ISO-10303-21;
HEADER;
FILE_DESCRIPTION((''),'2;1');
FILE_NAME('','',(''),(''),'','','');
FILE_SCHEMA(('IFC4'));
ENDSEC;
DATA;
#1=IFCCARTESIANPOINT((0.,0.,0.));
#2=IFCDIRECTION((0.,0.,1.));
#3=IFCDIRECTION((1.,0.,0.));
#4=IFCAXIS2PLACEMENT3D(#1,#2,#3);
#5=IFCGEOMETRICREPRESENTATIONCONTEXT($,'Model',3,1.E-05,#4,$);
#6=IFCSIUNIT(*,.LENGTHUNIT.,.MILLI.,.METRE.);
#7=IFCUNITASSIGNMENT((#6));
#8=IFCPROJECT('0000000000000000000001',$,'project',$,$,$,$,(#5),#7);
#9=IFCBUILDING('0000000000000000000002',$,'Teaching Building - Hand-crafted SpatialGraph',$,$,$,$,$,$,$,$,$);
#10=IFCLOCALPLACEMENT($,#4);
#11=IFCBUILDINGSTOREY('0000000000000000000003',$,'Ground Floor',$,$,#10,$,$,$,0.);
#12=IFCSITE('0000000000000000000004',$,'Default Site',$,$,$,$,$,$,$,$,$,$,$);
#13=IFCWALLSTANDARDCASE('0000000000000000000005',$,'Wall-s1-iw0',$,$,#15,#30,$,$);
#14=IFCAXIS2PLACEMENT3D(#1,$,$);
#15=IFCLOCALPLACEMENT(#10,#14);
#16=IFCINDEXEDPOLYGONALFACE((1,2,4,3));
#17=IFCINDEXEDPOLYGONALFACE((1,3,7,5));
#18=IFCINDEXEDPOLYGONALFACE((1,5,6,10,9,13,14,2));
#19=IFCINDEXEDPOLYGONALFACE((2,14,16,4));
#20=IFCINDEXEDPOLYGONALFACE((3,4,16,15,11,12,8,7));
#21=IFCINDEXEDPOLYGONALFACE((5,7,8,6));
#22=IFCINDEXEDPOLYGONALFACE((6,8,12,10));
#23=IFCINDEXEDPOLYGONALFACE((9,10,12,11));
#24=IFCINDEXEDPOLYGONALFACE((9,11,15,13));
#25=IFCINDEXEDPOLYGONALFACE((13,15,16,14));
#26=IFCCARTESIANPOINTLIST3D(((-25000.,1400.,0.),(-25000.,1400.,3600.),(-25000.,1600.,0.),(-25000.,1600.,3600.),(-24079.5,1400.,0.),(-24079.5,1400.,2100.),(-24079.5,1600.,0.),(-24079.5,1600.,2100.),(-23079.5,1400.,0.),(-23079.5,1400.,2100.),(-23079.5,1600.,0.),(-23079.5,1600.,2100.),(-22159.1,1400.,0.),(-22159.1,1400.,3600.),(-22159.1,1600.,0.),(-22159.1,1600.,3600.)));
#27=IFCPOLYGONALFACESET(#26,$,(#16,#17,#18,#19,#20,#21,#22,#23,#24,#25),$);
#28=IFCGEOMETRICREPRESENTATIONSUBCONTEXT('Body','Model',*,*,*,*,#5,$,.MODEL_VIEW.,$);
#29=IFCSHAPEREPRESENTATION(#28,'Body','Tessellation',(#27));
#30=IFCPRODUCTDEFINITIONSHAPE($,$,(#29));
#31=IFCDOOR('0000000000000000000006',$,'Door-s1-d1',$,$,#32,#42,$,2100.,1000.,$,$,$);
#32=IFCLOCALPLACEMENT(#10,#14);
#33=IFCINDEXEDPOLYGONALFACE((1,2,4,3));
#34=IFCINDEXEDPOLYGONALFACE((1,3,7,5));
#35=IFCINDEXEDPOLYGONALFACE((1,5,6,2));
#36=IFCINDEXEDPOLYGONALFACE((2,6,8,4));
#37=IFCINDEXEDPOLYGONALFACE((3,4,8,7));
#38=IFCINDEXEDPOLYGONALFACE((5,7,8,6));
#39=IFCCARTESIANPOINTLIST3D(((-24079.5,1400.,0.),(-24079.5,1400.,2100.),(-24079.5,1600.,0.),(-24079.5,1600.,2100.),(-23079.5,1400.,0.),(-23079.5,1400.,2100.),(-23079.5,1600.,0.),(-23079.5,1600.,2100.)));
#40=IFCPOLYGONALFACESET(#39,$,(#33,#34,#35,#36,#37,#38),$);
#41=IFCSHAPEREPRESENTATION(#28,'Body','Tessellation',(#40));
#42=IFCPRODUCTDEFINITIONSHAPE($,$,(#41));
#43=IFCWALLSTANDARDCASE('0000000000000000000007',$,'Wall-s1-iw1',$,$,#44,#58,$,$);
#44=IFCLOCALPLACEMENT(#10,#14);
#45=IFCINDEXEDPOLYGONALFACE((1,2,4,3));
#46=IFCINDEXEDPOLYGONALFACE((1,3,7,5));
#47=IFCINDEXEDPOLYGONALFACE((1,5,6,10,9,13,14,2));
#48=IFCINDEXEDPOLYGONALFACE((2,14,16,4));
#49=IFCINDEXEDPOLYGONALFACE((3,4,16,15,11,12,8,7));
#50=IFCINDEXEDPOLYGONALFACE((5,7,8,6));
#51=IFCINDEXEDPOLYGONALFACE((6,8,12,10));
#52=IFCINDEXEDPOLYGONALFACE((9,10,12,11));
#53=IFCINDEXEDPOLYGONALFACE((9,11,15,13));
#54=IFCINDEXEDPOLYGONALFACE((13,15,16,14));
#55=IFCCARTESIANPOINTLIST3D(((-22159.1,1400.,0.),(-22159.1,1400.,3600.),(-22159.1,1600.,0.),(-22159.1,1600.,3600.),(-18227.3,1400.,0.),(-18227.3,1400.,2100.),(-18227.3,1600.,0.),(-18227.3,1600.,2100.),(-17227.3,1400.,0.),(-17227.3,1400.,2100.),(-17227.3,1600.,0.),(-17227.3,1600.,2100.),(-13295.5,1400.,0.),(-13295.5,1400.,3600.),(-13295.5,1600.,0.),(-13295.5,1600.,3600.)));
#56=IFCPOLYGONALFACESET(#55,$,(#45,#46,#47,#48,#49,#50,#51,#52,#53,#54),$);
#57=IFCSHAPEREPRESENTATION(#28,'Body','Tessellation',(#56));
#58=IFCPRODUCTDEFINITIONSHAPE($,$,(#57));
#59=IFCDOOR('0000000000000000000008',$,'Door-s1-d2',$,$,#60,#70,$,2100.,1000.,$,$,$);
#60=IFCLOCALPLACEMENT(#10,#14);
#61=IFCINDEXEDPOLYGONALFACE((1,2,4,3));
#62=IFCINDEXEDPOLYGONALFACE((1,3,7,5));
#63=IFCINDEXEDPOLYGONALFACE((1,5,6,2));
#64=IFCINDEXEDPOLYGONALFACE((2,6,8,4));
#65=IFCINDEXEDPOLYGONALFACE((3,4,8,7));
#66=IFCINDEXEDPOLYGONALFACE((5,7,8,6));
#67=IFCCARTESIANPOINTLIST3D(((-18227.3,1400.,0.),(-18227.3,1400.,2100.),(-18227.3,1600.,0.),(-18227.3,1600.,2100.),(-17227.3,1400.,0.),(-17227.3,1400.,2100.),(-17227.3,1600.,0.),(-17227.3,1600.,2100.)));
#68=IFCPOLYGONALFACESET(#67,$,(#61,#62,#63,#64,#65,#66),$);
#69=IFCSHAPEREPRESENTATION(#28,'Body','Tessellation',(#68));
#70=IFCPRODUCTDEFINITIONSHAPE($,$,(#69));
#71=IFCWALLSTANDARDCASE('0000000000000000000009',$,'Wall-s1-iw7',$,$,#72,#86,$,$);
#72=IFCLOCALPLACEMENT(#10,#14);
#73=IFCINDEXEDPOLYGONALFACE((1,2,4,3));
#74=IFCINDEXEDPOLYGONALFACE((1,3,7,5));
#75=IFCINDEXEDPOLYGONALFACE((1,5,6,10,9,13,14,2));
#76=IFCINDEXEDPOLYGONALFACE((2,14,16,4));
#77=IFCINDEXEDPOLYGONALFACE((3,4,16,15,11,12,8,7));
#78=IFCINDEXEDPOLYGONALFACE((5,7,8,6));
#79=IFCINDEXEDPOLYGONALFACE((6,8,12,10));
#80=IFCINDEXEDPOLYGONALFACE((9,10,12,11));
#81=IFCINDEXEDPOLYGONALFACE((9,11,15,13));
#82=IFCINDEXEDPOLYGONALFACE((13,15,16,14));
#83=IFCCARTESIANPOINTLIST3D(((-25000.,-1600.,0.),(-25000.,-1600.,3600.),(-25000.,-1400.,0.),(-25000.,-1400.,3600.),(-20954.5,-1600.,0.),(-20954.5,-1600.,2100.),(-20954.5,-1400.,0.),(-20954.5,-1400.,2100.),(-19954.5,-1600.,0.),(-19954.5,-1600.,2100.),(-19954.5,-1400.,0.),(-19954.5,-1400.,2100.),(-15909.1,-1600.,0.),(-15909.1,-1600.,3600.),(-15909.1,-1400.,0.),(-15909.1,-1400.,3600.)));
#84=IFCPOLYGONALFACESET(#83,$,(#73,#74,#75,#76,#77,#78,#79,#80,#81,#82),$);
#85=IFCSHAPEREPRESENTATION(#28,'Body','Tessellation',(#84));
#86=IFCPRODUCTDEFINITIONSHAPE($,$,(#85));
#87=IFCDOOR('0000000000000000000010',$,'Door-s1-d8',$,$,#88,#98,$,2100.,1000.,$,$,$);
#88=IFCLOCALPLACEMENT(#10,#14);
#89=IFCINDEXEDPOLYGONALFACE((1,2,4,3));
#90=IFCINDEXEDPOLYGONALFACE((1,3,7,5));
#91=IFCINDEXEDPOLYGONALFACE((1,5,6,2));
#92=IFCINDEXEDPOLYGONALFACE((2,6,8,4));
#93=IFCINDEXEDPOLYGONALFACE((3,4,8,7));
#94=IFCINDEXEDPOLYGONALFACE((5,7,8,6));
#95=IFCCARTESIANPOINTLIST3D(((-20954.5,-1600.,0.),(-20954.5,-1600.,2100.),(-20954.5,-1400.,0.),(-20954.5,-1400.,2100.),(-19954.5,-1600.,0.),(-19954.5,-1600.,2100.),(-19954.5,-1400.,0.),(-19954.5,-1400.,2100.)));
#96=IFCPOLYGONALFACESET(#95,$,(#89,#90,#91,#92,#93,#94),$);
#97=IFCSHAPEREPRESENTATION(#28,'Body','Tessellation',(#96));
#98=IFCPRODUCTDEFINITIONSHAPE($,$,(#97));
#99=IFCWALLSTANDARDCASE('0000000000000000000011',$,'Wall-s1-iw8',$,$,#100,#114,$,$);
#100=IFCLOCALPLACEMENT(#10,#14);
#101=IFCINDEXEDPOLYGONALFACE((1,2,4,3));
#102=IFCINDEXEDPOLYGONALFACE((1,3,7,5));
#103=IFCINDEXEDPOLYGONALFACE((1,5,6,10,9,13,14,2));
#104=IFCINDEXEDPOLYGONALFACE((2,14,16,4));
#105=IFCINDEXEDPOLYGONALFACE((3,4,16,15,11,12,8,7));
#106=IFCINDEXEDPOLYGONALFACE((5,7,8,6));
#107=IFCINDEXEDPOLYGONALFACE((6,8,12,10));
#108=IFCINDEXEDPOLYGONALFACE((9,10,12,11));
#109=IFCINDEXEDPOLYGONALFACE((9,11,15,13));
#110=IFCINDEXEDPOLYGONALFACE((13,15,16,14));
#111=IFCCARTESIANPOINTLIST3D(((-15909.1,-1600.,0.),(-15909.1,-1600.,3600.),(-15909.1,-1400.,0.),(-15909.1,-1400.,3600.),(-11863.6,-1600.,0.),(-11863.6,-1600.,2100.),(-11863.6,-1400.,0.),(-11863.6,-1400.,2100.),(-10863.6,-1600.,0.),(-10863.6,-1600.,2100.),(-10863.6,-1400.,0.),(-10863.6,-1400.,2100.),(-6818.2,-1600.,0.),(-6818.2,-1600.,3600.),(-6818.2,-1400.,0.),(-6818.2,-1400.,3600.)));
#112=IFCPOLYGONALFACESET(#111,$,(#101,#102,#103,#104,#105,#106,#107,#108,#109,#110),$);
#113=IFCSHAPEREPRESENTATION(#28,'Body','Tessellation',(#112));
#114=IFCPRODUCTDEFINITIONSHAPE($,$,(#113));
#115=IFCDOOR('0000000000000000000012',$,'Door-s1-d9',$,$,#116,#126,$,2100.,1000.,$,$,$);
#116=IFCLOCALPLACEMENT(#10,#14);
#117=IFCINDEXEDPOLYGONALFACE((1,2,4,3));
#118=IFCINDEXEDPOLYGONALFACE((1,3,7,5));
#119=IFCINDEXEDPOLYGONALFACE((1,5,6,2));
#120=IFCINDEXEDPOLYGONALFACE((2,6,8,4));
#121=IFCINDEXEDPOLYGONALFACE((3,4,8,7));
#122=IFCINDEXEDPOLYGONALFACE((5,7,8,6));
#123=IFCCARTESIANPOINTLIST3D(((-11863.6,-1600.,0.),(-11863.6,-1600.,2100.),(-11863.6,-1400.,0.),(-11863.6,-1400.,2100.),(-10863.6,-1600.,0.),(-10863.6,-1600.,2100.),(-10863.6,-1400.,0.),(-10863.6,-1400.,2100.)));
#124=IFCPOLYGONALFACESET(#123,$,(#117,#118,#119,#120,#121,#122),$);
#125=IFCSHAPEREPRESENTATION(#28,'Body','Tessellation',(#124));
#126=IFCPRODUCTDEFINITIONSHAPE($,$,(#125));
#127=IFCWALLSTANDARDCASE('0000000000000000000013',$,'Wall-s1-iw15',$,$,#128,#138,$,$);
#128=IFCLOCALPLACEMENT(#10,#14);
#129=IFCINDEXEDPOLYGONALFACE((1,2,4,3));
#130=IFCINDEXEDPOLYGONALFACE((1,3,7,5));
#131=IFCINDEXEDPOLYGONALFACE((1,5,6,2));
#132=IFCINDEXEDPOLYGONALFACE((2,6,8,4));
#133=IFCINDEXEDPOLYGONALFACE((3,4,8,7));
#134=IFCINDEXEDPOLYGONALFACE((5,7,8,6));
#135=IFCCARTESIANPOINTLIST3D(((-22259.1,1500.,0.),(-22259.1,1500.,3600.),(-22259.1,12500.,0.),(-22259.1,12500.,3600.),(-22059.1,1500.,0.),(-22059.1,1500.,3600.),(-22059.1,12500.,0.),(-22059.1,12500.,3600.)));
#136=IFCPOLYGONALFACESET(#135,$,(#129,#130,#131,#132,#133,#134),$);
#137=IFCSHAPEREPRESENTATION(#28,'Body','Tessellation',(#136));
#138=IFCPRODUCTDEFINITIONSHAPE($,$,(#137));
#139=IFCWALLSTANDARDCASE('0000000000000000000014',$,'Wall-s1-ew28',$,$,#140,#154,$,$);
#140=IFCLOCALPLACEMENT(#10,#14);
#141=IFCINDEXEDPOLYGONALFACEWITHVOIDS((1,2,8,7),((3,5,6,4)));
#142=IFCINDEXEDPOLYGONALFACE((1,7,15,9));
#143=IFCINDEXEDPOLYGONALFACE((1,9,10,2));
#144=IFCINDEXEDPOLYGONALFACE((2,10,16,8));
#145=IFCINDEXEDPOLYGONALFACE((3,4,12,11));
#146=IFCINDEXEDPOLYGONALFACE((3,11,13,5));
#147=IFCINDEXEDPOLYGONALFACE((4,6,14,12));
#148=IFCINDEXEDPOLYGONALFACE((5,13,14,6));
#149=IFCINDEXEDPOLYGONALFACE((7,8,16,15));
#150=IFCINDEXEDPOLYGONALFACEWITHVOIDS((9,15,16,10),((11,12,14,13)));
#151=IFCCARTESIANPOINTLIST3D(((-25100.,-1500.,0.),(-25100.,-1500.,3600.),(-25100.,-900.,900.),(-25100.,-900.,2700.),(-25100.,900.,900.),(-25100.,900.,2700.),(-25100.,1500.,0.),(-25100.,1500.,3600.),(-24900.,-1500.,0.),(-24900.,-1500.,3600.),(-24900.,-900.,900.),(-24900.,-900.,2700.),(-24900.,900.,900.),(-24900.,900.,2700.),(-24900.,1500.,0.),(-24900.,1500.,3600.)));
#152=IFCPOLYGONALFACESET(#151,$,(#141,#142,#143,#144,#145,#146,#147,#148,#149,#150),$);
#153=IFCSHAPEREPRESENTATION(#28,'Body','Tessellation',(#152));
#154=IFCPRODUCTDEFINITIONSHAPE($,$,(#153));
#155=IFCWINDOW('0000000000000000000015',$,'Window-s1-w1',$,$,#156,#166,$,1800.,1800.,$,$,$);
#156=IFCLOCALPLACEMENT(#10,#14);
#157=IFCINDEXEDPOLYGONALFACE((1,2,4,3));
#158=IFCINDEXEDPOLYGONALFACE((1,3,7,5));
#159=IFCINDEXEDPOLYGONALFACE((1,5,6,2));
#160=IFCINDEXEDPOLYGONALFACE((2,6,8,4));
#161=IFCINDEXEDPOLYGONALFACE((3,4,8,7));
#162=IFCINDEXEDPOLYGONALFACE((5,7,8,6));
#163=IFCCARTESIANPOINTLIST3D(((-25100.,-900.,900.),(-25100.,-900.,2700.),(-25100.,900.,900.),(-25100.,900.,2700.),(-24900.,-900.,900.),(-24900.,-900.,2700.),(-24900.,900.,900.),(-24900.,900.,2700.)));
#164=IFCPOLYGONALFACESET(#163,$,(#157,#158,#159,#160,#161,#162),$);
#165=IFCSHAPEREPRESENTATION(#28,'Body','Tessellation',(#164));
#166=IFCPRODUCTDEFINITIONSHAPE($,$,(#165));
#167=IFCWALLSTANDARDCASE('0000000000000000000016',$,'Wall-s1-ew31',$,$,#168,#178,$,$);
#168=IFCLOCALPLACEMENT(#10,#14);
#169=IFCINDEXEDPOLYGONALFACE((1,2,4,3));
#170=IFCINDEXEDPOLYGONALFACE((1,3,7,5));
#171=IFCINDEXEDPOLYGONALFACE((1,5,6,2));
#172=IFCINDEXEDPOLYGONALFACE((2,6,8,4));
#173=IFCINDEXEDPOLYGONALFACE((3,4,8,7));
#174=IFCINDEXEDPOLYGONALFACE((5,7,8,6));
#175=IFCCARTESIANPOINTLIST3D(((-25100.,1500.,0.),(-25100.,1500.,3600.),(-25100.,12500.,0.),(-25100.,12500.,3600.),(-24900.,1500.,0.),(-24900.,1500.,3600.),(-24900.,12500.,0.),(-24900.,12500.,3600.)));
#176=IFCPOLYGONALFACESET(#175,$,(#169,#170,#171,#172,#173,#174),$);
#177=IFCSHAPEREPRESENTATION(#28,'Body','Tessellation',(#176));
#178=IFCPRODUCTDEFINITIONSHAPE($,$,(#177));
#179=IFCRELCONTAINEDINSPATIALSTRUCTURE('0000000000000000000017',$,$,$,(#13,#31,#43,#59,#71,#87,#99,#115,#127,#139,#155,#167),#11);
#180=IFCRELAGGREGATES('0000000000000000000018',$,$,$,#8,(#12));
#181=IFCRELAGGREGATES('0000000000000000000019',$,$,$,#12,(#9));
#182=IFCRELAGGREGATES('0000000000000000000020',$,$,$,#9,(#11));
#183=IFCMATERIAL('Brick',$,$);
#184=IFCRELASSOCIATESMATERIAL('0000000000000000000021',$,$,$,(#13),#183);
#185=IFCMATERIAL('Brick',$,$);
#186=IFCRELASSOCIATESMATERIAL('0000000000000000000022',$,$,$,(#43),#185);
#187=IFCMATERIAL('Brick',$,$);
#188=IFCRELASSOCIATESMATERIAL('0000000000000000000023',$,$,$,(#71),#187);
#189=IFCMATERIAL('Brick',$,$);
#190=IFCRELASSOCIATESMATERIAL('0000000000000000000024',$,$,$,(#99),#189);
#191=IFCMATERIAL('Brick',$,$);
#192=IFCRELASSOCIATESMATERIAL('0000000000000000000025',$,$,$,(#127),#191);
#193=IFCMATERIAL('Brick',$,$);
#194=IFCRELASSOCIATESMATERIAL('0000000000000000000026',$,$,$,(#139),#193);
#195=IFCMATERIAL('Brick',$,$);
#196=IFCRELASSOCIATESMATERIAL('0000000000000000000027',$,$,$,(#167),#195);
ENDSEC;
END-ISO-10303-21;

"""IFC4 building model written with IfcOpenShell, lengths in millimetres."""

from ifc_helpers import new_model, si_unit, frame, frame_2d, origin_with_axes, place, context, subcontext, project, spatial, rectangle, extrude, material, element, fill, save


model = new_model("IFC4")

# Units and contexts
model_context = context("Model", 3, precision=1e-05, world=origin_with_axes())
body_context = subcontext(model_context, "Body", "Model", "MODEL_VIEW")
ifc_project = project(units=[si_unit("LENGTHUNIT", "METRE", prefix="MILLI")], contexts=[model_context])

# Site, building, storey
site = spatial("IfcSite", under=ifc_project, Name="Default Site")
building = spatial("IfcBuilding", under=site, Name="Teaching Building - Hand-crafted SpatialGraph")
storey_placement = place(None, origin_with_axes())
storey = spatial("IfcBuildingStorey", under=building, at=storey_placement, Name="Ground Floor", Elevation=0.0)

# Walls, openings, doors
ifc_material_1 = material(Name="Brick")
wall_1_placement = place(storey_placement, frame((-25000.0, 1500.0, 0.0), z_axis=(0.0, 0.0, 1.0), x_axis=(1.0, 0.0, 0.0)))
wall_1 = element("IfcWallStandardCase", 1, at=wall_1_placement, inside=storey, material=ifc_material_1, Name="Wall-s1-iw0", context=body_context, shape_type="SweptSolid", body=[
    extrude(rectangle(XDim=2840.9, YDim=200.0, at=frame_2d((1420.5, 0.0))), origin_with_axes(), (0.0, 0.0, 1.0), 3600.0),
])
opening_1_placement = place(wall_1_placement, frame((920.5, 0.0, 0.0), z_axis=(0.0, 0.0, 1.0), x_axis=(1.0, 0.0, 0.0)))
opening_1 = element("IfcOpeningElement", 2, at=opening_1_placement, cuts=wall_1, context=body_context, shape_type="SweptSolid", body=[
    extrude(rectangle(XDim=1000.0, YDim=400.0, at=frame_2d((500.0, 0.0))), origin_with_axes(), (0.0, 0.0, 1.0), 2100.0),
])
door_1_placement = place(storey_placement, frame((-24079.5, 1500.0, 0.0), z_axis=(0.0, 0.0, 1.0), x_axis=(1.0, 0.0, 0.0)))
door_1 = element("IfcDoor", 3, at=door_1_placement, inside=storey, Name="Door-s1-d1", OverallHeight=2100.0, OverallWidth=1000.0, context=body_context, shape_type="SweptSolid", body=[
    extrude(rectangle(XDim=1000.0, YDim=200.0, at=frame_2d((500.0, 0.0))), origin_with_axes(), (0.0, 0.0, 1.0), 2100.0),
])
fill(opening_1, door_1)
ifc_material_2 = material(Name="Brick")
wall_2_placement = place(storey_placement, frame((-22159.1, 1500.0, 0.0), z_axis=(0.0, 0.0, 1.0), x_axis=(1.0, 0.0, 0.0)))
wall_2 = element("IfcWallStandardCase", 4, at=wall_2_placement, inside=storey, material=ifc_material_2, Name="Wall-s1-iw1", context=body_context, shape_type="SweptSolid", body=[
    extrude(rectangle(XDim=8863.6, YDim=200.0, at=frame_2d((4431.8, 0.0))), origin_with_axes(), (0.0, 0.0, 1.0), 3600.0),
])
opening_2_placement = place(wall_2_placement, frame((3931.8, 0.0, 0.0), z_axis=(0.0, 0.0, 1.0), x_axis=(1.0, 0.0, 0.0)))
opening_2 = element("IfcOpeningElement", 5, at=opening_2_placement, cuts=wall_2, context=body_context, shape_type="SweptSolid", body=[
    extrude(rectangle(XDim=1000.0, YDim=400.0, at=frame_2d((500.0, 0.0))), origin_with_axes(), (0.0, 0.0, 1.0), 2100.0),
])
door_2_placement = place(storey_placement, frame((-18227.3, 1500.0, 0.0), z_axis=(0.0, 0.0, 1.0), x_axis=(1.0, 0.0, 0.0)))
door_2 = element("IfcDoor", 6, at=door_2_placement, inside=storey, Name="Door-s1-d2", OverallHeight=2100.0, OverallWidth=1000.0, context=body_context, shape_type="SweptSolid", body=[
    extrude(rectangle(XDim=1000.0, YDim=200.0, at=frame_2d((500.0, 0.0))), origin_with_axes(), (0.0, 0.0, 1.0), 2100.0),
])
fill(opening_2, door_2)
ifc_material_3 = material(Name="Brick")
wall_3_placement = place(storey_placement, frame((-25000.0, -1500.0, 0.0), z_axis=(0.0, 0.0, 1.0), x_axis=(1.0, 0.0, 0.0)))
wall_3 = element("IfcWallStandardCase", 7, at=wall_3_placement, inside=storey, material=ifc_material_3, Name="Wall-s1-iw7", context=body_context, shape_type="SweptSolid", body=[
    extrude(rectangle(XDim=9090.9, YDim=200.0, at=frame_2d((4545.5, 0.0))), origin_with_axes(), (0.0, 0.0, 1.0), 3600.0),
])
opening_3_placement = place(wall_3_placement, frame((4045.5, 0.0, 0.0), z_axis=(0.0, 0.0, 1.0), x_axis=(1.0, 0.0, 0.0)))
opening_3 = element("IfcOpeningElement", 8, at=opening_3_placement, cuts=wall_3, context=body_context, shape_type="SweptSolid", body=[
    extrude(rectangle(XDim=1000.0, YDim=400.0, at=frame_2d((500.0, 0.0))), origin_with_axes(), (0.0, 0.0, 1.0), 2100.0),
])
door_3_placement = place(storey_placement, frame((-20954.5, -1500.0, 0.0), z_axis=(0.0, 0.0, 1.0), x_axis=(1.0, 0.0, 0.0)))
door_3 = element("IfcDoor", 9, at=door_3_placement, inside=storey, Name="Door-s1-d8", OverallHeight=2100.0, OverallWidth=1000.0, context=body_context, shape_type="SweptSolid", body=[
    extrude(rectangle(XDim=1000.0, YDim=200.0, at=frame_2d((500.0, 0.0))), origin_with_axes(), (0.0, 0.0, 1.0), 2100.0),
])
fill(opening_3, door_3)
ifc_material_4 = material(Name="Brick")
wall_4_placement = place(storey_placement, frame((-15909.1, -1500.0, 0.0), z_axis=(0.0, 0.0, 1.0), x_axis=(1.0, 0.0, 0.0)))
wall_4 = element("IfcWallStandardCase", 10, at=wall_4_placement, inside=storey, material=ifc_material_4, Name="Wall-s1-iw8", context=body_context, shape_type="SweptSolid", body=[
    extrude(rectangle(XDim=9090.9, YDim=200.0, at=frame_2d((4545.5, 0.0))), origin_with_axes(), (0.0, 0.0, 1.0), 3600.0),
])
opening_4_placement = place(wall_4_placement, frame((4045.5, 0.0, 0.0), z_axis=(0.0, 0.0, 1.0), x_axis=(1.0, 0.0, 0.0)))
opening_4 = element("IfcOpeningElement", 11, at=opening_4_placement, cuts=wall_4, context=body_context, shape_type="SweptSolid", body=[
    extrude(rectangle(XDim=1000.0, YDim=400.0, at=frame_2d((500.0, 0.0))), origin_with_axes(), (0.0, 0.0, 1.0), 2100.0),
])
door_4_placement = place(storey_placement, frame((-11863.6, -1500.0, 0.0), z_axis=(0.0, 0.0, 1.0), x_axis=(1.0, 0.0, 0.0)))
door_4 = element("IfcDoor", 12, at=door_4_placement, inside=storey, Name="Door-s1-d9", OverallHeight=2100.0, OverallWidth=1000.0, context=body_context, shape_type="SweptSolid", body=[
    extrude(rectangle(XDim=1000.0, YDim=200.0, at=frame_2d((500.0, 0.0))), origin_with_axes(), (0.0, 0.0, 1.0), 2100.0),
])
fill(opening_4, door_4)

# Wall
ifc_material_5 = material(Name="Brick")
wall_5_placement = place(storey_placement, frame((-22159.1, 1500.0, 0.0), z_axis=(0.0, 0.0, 1.0), x_axis=(0.0, 1.0, 0.0)))
element("IfcWallStandardCase", 13, at=wall_5_placement, inside=storey, material=ifc_material_5, Name="Wall-s1-iw15", context=body_context, shape_type="SweptSolid", body=[
    extrude(rectangle(XDim=11000.0, YDim=200.0, at=frame_2d((5500.0, 0.0))), origin_with_axes(), (0.0, 0.0, 1.0), 3600.0),
])

# Wall, opening, window
ifc_material_6 = material(Name="Brick")
wall_6_placement = place(storey_placement, frame((-25000.0, -1500.0, 0.0), z_axis=(0.0, 0.0, 1.0), x_axis=(0.0, 1.0, 0.0)))
wall_6 = element("IfcWallStandardCase", 14, at=wall_6_placement, inside=storey, material=ifc_material_6, Name="Wall-s1-ew28", context=body_context, shape_type="SweptSolid", body=[
    extrude(rectangle(XDim=3000.0, YDim=200.0, at=frame_2d((1500.0, 0.0))), origin_with_axes(), (0.0, 0.0, 1.0), 3600.0),
])
opening_5_placement = place(wall_6_placement, frame((600.0, 0.0, 900.0), z_axis=(0.0, 0.0, 1.0), x_axis=(1.0, 0.0, 0.0)))
opening_5 = element("IfcOpeningElement", 15, at=opening_5_placement, cuts=wall_6, context=body_context, shape_type="SweptSolid", body=[
    extrude(rectangle(XDim=1800.0, YDim=400.0, at=frame_2d((900.0, 0.0))), origin_with_axes(), (0.0, 0.0, 1.0), 1800.0),
])
window_placement = place(storey_placement, frame((-25000.0, -900.0, 900.0), z_axis=(0.0, 0.0, 1.0), x_axis=(0.0, 1.0, 0.0)))
window = element("IfcWindow", 16, at=window_placement, inside=storey, Name="Window-s1-w1", OverallHeight=1800.0, OverallWidth=1800.0, context=body_context, shape_type="SweptSolid", body=[
    extrude(rectangle(XDim=1800.0, YDim=200.0, at=frame_2d((900.0, 0.0))), origin_with_axes(), (0.0, 0.0, 1.0), 1800.0),
])
fill(opening_5, window)

# Wall
ifc_material_7 = material(Name="Brick")
wall_7_placement = place(storey_placement, frame((-25000.0, 1500.0, 0.0), z_axis=(0.0, 0.0, 1.0), x_axis=(0.0, 1.0, 0.0)))
element("IfcWallStandardCase", 17, at=wall_7_placement, inside=storey, material=ifc_material_7, Name="Wall-s1-ew31", context=body_context, shape_type="SweptSolid", body=[
    extrude(rectangle(XDim=11000.0, YDim=200.0, at=frame_2d((5500.0, 0.0))), origin_with_axes(), (0.0, 0.0, 1.0), 3600.0),
])

save(model, "model.ifc")
